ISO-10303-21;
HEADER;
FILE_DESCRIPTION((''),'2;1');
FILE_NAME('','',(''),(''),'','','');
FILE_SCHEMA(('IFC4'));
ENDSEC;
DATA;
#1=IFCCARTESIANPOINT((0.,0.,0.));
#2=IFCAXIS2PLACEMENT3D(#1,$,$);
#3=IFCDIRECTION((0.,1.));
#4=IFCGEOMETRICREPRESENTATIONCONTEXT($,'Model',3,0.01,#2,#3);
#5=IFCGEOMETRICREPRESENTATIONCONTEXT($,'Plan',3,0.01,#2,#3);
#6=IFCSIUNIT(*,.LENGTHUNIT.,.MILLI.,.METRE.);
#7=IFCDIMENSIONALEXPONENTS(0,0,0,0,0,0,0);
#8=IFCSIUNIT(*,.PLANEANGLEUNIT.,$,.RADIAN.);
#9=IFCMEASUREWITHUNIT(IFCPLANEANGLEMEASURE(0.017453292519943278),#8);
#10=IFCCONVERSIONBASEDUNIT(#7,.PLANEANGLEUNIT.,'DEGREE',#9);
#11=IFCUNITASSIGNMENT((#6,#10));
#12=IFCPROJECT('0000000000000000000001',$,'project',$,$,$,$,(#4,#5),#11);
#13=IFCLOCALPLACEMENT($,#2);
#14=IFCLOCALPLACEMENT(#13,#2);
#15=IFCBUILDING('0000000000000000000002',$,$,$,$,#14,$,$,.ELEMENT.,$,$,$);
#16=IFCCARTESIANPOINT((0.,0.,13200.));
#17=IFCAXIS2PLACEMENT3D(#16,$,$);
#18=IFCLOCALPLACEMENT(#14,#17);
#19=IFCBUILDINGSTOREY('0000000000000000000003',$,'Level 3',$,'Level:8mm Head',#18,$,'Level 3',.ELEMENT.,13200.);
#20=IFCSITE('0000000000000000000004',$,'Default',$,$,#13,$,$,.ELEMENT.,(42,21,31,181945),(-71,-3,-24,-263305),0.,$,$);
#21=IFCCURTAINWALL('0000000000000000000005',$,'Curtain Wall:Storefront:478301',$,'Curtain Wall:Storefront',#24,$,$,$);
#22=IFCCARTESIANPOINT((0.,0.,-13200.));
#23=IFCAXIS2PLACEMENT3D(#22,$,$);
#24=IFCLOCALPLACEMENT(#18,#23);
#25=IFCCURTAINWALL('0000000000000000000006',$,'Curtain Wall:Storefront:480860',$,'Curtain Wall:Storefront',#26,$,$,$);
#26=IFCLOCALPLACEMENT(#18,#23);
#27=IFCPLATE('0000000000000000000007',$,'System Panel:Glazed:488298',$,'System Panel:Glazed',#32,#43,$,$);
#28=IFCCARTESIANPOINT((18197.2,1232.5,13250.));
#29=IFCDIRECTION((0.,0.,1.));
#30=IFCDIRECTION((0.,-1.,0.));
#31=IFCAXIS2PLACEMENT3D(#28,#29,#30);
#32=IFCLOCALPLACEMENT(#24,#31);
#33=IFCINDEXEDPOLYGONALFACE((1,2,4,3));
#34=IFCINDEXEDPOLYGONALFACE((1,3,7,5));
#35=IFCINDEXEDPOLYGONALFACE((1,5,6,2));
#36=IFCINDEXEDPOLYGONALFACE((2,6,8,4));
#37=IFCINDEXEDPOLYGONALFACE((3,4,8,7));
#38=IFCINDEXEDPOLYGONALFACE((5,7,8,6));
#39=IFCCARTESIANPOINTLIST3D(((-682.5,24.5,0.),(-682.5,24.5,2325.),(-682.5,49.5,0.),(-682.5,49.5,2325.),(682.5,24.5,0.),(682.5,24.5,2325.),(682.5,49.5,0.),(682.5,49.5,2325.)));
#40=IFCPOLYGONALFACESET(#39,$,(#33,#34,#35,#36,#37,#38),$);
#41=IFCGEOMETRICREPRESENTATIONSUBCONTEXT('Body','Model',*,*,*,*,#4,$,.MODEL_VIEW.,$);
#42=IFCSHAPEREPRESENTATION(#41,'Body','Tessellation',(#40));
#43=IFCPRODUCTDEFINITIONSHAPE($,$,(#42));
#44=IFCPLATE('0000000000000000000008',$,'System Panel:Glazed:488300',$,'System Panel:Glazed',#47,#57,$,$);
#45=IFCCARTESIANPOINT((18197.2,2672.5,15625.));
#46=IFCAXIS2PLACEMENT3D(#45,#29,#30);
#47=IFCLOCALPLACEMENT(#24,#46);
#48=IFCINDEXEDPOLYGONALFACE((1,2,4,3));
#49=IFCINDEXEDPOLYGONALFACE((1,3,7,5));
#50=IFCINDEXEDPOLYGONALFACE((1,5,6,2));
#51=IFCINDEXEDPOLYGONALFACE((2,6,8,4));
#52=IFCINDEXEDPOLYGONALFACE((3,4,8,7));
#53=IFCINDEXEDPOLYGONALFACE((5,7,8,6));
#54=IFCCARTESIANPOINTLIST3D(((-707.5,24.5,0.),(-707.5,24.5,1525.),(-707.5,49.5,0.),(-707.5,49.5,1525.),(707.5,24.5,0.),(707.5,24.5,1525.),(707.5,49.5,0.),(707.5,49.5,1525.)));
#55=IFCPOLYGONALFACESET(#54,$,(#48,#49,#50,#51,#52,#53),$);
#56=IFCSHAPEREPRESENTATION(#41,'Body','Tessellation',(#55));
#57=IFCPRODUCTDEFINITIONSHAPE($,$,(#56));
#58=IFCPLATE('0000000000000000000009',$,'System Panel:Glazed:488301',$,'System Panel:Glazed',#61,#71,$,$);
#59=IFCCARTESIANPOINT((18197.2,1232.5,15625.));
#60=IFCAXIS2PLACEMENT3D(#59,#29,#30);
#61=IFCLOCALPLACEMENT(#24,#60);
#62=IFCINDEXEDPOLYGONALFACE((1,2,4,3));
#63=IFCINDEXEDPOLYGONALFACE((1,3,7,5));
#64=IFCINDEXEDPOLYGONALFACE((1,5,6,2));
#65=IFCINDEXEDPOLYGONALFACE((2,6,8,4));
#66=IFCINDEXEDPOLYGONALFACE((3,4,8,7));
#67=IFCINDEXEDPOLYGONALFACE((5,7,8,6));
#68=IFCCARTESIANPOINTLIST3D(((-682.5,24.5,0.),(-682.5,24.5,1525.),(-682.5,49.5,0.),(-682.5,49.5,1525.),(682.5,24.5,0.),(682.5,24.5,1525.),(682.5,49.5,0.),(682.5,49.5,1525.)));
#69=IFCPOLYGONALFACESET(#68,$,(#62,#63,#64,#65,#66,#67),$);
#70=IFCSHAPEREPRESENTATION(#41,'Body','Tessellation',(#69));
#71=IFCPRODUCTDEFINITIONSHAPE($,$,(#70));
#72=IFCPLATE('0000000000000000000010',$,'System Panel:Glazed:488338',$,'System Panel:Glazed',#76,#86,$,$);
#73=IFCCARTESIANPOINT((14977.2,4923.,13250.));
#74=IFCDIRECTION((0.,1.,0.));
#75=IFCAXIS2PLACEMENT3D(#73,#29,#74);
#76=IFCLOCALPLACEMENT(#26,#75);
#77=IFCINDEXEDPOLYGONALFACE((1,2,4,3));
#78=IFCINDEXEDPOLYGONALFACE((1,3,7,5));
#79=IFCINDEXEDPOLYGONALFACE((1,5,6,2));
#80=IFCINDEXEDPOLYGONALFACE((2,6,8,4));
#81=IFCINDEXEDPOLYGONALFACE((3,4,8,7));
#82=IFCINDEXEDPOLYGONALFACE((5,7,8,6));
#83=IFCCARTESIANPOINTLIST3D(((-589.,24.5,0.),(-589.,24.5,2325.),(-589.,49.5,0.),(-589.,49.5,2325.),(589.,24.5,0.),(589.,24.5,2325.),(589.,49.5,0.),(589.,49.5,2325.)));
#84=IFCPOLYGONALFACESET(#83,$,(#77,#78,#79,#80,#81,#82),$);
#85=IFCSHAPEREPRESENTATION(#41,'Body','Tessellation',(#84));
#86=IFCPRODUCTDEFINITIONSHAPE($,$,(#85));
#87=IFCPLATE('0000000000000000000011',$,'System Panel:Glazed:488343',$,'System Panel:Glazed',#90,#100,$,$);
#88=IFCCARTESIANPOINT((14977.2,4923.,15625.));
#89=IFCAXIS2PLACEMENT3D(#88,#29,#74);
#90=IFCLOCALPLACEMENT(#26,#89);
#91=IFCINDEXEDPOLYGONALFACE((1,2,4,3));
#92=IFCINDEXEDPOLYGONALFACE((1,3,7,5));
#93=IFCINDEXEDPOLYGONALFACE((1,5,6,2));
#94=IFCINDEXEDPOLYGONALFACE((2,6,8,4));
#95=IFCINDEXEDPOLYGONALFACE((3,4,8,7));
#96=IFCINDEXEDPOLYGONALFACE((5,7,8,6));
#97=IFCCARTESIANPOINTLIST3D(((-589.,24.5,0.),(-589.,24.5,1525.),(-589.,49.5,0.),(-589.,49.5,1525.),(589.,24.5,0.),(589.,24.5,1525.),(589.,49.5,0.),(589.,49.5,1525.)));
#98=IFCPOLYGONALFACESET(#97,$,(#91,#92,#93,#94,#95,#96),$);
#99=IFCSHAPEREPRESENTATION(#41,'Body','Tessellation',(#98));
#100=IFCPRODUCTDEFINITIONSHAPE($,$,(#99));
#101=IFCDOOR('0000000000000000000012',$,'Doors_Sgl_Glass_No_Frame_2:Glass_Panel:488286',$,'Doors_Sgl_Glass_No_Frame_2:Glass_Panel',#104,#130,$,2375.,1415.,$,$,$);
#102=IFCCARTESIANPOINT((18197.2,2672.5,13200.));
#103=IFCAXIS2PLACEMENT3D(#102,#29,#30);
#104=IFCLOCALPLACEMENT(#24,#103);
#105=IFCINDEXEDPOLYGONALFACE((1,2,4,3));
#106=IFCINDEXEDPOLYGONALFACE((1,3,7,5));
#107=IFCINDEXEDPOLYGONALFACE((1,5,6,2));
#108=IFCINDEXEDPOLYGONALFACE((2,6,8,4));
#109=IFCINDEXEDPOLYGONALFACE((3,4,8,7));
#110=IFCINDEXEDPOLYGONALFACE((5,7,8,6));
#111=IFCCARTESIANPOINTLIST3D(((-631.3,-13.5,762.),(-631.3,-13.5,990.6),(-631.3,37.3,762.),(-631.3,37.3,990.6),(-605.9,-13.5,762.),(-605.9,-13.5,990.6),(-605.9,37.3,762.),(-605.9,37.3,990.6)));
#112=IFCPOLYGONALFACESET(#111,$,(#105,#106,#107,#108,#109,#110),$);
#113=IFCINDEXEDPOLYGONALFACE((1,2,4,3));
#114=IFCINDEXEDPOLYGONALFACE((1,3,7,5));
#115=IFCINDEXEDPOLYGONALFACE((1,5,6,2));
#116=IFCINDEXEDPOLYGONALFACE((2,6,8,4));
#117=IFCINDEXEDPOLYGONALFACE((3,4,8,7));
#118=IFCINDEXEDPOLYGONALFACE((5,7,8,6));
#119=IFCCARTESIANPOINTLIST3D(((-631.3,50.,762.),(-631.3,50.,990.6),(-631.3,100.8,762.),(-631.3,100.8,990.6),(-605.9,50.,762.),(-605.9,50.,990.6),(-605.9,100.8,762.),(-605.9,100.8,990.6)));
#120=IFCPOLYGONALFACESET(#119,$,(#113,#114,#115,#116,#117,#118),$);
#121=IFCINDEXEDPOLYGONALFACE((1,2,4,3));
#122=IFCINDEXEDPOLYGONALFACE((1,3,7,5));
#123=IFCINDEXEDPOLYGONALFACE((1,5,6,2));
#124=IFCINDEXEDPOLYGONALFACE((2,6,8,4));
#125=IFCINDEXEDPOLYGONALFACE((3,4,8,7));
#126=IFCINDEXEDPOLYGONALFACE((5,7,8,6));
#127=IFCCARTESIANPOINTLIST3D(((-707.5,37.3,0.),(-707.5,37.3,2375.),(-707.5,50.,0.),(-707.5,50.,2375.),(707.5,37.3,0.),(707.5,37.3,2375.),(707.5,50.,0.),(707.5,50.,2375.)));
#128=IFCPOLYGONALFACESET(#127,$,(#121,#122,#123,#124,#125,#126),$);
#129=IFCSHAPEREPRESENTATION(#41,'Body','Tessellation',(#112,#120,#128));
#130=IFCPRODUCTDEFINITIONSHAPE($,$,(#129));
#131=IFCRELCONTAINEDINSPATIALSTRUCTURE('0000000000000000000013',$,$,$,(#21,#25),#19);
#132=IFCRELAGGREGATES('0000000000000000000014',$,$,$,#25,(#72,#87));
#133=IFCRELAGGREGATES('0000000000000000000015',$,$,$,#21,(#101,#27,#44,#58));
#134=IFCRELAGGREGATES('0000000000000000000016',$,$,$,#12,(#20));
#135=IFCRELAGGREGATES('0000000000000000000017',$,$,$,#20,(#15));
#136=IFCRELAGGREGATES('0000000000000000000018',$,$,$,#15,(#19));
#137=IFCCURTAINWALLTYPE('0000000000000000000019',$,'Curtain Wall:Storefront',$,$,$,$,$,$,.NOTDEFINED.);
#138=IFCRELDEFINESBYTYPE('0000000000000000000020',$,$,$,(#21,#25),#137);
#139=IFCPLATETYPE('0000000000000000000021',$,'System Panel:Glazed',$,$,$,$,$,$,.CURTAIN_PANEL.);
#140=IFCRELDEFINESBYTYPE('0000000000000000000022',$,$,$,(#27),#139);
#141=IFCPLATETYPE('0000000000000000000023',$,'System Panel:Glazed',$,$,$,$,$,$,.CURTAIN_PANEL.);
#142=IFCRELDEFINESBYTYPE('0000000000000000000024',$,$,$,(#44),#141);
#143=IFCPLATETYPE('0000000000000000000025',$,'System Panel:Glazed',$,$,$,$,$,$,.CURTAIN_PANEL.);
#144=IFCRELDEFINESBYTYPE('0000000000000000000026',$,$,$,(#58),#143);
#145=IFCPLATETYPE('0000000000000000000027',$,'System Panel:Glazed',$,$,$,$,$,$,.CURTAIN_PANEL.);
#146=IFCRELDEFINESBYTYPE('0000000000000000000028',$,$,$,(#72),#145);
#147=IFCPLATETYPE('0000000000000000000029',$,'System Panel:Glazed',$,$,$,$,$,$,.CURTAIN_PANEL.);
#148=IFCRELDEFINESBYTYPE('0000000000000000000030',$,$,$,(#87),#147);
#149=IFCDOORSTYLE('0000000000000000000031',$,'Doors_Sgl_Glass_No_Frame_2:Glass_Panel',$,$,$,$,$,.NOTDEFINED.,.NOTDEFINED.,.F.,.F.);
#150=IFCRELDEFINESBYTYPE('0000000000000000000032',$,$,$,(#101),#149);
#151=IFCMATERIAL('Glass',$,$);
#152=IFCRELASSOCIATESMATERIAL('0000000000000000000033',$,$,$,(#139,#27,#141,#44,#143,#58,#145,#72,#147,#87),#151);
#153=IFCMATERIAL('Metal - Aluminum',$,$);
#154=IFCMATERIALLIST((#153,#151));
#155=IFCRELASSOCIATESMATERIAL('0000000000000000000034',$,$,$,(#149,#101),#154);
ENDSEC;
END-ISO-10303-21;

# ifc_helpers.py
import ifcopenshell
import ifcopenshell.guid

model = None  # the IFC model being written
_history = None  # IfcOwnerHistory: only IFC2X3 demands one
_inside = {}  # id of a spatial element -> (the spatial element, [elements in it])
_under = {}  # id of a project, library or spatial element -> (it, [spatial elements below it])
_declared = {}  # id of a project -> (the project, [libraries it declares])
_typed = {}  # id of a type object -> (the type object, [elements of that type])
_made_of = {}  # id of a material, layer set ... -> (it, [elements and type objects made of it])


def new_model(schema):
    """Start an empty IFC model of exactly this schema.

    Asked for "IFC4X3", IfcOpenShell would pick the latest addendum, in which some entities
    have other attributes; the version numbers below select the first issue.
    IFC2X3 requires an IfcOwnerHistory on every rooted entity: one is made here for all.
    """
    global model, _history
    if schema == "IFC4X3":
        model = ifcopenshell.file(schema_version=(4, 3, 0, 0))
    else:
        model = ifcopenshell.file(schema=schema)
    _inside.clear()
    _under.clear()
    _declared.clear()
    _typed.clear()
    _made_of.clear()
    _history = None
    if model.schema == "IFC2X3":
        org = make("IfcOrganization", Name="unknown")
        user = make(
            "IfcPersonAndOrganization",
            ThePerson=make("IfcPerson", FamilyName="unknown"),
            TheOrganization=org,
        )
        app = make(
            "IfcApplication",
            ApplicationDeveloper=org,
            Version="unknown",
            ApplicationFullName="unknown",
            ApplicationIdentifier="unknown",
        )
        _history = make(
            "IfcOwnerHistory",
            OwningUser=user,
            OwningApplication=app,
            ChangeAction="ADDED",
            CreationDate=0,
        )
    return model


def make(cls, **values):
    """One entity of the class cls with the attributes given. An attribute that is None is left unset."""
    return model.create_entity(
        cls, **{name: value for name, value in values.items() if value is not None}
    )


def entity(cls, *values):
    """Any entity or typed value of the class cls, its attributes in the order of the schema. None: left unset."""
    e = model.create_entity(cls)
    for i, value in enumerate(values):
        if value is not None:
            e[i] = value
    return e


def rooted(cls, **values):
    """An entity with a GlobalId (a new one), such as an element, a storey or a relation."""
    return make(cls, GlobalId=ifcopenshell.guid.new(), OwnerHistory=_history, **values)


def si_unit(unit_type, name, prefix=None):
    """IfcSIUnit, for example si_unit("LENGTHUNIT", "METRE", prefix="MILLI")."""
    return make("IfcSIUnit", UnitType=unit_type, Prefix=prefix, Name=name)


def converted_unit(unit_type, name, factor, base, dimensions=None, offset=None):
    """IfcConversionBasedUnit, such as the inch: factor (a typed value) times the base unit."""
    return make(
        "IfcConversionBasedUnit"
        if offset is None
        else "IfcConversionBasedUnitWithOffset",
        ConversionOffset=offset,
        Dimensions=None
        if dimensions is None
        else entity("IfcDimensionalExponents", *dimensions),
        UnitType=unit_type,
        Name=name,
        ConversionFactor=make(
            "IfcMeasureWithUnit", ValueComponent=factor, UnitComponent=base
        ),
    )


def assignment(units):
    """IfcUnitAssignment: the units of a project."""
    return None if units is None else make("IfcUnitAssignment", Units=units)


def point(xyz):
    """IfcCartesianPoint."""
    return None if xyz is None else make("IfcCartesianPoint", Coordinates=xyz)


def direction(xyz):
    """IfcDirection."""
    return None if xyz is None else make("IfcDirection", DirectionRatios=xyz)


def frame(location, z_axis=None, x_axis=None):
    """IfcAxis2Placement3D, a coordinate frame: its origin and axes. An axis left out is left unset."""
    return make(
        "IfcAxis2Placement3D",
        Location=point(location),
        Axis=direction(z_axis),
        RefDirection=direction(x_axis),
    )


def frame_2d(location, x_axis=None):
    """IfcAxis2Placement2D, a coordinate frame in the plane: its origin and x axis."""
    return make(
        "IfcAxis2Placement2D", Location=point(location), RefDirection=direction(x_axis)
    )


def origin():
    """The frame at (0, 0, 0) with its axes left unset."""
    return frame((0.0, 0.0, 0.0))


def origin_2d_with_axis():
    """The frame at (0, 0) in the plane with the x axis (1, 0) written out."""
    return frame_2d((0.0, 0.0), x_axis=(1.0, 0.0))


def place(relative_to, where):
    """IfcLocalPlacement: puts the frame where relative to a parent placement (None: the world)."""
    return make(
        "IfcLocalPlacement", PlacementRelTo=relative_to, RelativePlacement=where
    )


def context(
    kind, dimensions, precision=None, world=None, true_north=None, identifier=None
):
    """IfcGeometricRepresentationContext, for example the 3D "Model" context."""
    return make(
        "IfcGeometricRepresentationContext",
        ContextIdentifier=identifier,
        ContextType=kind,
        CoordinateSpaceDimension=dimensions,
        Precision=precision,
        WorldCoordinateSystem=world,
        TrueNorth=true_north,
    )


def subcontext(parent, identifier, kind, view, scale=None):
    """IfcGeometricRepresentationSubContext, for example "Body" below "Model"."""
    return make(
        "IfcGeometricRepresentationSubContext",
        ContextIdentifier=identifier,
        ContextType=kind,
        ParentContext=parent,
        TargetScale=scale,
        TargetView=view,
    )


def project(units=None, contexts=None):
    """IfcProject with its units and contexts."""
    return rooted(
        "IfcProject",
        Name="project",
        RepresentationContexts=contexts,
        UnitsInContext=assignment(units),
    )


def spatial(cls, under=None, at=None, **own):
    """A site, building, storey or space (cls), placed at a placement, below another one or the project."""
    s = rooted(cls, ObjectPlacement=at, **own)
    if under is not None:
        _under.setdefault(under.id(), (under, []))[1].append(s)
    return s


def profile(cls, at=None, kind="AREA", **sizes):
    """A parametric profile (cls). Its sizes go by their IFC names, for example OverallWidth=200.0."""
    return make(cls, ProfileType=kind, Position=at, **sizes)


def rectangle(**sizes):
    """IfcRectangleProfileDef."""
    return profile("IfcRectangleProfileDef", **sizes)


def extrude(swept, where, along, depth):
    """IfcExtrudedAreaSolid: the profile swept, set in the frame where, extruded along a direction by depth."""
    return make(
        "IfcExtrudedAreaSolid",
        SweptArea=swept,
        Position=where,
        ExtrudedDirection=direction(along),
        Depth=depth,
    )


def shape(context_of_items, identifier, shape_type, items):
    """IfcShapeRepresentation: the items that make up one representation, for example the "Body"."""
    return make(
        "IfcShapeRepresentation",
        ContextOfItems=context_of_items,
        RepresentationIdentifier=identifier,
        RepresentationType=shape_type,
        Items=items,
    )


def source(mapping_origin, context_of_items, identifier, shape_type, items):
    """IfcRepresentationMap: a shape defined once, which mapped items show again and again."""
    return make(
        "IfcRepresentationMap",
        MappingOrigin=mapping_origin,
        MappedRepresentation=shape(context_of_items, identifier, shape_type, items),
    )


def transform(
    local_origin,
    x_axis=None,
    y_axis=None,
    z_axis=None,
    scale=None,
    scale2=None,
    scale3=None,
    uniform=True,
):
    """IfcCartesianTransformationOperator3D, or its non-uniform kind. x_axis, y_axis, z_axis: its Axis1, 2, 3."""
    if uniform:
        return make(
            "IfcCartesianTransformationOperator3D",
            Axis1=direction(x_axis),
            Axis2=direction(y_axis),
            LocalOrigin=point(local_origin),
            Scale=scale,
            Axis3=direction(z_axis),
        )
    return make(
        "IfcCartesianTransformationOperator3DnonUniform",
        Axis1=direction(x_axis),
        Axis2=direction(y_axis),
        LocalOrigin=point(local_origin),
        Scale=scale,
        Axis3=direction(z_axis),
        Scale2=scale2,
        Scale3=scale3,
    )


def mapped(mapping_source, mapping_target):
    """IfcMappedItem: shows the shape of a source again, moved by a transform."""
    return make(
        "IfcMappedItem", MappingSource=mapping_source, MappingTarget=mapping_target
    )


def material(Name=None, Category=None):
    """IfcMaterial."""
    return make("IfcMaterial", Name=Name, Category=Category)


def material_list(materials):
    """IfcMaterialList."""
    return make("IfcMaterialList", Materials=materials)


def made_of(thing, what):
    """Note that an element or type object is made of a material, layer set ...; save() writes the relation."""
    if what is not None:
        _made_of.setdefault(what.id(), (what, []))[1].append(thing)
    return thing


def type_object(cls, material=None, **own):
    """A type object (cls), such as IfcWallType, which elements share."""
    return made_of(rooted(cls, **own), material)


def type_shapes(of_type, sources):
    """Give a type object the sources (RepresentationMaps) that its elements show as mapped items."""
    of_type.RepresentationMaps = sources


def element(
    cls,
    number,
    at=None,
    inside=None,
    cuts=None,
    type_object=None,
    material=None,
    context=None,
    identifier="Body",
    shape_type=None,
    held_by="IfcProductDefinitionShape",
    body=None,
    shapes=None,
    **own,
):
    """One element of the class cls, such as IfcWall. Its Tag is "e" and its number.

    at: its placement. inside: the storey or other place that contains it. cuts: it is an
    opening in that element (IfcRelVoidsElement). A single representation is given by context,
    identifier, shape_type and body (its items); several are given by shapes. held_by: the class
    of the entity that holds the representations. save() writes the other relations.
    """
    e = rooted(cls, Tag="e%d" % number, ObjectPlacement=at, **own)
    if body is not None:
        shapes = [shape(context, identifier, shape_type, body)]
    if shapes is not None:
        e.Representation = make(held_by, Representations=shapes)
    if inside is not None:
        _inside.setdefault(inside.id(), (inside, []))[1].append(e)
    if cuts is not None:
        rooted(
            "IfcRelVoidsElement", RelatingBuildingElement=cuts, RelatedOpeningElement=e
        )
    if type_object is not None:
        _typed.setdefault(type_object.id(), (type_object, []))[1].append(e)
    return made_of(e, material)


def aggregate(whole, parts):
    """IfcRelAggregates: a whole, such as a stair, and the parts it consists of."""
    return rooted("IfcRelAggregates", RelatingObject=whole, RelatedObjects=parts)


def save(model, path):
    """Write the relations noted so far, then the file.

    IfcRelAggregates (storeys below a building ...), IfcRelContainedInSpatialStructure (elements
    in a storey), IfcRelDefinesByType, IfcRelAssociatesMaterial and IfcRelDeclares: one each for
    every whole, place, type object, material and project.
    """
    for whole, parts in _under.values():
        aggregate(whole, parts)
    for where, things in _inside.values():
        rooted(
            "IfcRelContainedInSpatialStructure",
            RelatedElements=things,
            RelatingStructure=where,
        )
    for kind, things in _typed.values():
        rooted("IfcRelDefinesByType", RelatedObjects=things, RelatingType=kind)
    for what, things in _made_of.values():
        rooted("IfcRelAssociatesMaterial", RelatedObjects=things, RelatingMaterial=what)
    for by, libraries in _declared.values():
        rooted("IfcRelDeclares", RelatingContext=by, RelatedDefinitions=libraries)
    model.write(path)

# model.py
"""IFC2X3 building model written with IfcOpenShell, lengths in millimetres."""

from ifc_helpers import new_model, entity, si_unit, converted_unit, direction, frame, frame_2d, origin, origin_2d_with_axis, place, context, subcontext, project, spatial, rectangle, extrude, source, transform, mapped, material, material_list, type_object, type_shapes, element, aggregate, save


model = new_model("IFC2X3")

# Units and contexts
model_context = context("Model", 3, precision=0.01, world=origin(), true_north=direction((0.0, 1.0)))
plan_context = context("Plan", 3, precision=0.01, world=origin(), true_north=direction((0.0, 1.0)))
body_context = subcontext(model_context, "Body", "Model", "MODEL_VIEW")
ifc_project = project(units=[si_unit("LENGTHUNIT", "METRE", prefix="MILLI"), converted_unit("PLANEANGLEUNIT", "DEGREE", entity("IfcPlaneAngleMeasure", 0.017453292519943278), si_unit("PLANEANGLEUNIT", "RADIAN"), dimensions=[0, 0, 0, 0, 0, 0, 0])], contexts=[model_context, plan_context])

# Site, building, storey
site_placement = place(None, origin())
site = spatial("IfcSite", under=ifc_project, at=site_placement, Name="Default", CompositionType="ELEMENT", RefLatitude=(42, 21, 31, 181945), RefLongitude=(-71, -3, -24, -263305), RefElevation=0.0)
building_placement = place(site_placement, origin())
building = spatial("IfcBuilding", under=site, at=building_placement, CompositionType="ELEMENT")
storey_placement = place(building_placement, frame((0.0, 0.0, 13200.0)))
storey = spatial("IfcBuildingStorey", under=building, at=storey_placement, Name="Level 3", ObjectType="Level:8mm Head", LongName="Level 3", CompositionType="ELEMENT", Elevation=13200.0)

# Curtain walls
curtain_wall_type = type_object("IfcCurtainWallType", Name="Curtain Wall:Storefront", PredefinedType="NOTDEFINED")
curtain_wall_1_placement = place(storey_placement, frame((0.0, 0.0, -13200.0)))
curtain_wall_1 = element("IfcCurtainWall", 1, at=curtain_wall_1_placement, inside=storey, type_object=curtain_wall_type, Name="Curtain Wall:Storefront:478301", ObjectType="Curtain Wall:Storefront")
curtain_wall_2_placement = place(storey_placement, frame((0.0, 0.0, -13200.0)))
curtain_wall_2 = element("IfcCurtainWall", 2, at=curtain_wall_2_placement, inside=storey, type_object=curtain_wall_type, Name="Curtain Wall:Storefront:480860", ObjectType="Curtain Wall:Storefront")

# Plates
ifc_material_1 = material(Name="Glass")
plate_type_1 = type_object("IfcPlateType", Name="System Panel:Glazed", PredefinedType="CURTAIN_PANEL", material=ifc_material_1)
shared_shape_1 = source(origin(), body_context, "Body", "SweptSolid", [
    extrude(rectangle(XDim=25.0, YDim=1365.0, at=origin_2d_with_axis()), frame((0.0, 37.0, 0.0), z_axis=(0.0, 0.0, 1.0), x_axis=(0.0, 1.0, 0.0)), (0.0, 0.0, 1.0), 2325.0),
])
type_shapes(plate_type_1, [shared_shape_1])
plate_1_placement = place(curtain_wall_1_placement, frame((18197.2, 1232.5, 13250.0), z_axis=(0.0, 0.0, 1.0), x_axis=(0.0, -1.0, 0.0)))
plate_1 = element("IfcPlate", 3, at=plate_1_placement, type_object=plate_type_1, material=ifc_material_1, Name="System Panel:Glazed:488298", ObjectType="System Panel:Glazed", context=body_context, shape_type="MappedRepresentation", body=[
    mapped(shared_shape_1, transform((0.0, 0.0, 0.0), scale=1.0)),
])
plate_type_2 = type_object("IfcPlateType", Name="System Panel:Glazed", PredefinedType="CURTAIN_PANEL", material=ifc_material_1)
shared_shape_2 = source(origin(), body_context, "Body", "SweptSolid", [
    extrude(rectangle(XDim=25.0, YDim=1415.0, at=origin_2d_with_axis()), frame((0.0, 37.0, 0.0), z_axis=(0.0, 0.0, 1.0), x_axis=(0.0, 1.0, 0.0)), (0.0, 0.0, 1.0), 1525.0),
])
type_shapes(plate_type_2, [shared_shape_2])
plate_2_placement = place(curtain_wall_1_placement, frame((18197.2, 2672.5, 15625.0), z_axis=(0.0, 0.0, 1.0), x_axis=(0.0, -1.0, 0.0)))
plate_2 = element("IfcPlate", 4, at=plate_2_placement, type_object=plate_type_2, material=ifc_material_1, Name="System Panel:Glazed:488300", ObjectType="System Panel:Glazed", context=body_context, shape_type="MappedRepresentation", body=[
    mapped(shared_shape_2, transform((0.0, 0.0, 0.0), scale=1.0)),
])
plate_type_3 = type_object("IfcPlateType", Name="System Panel:Glazed", PredefinedType="CURTAIN_PANEL", material=ifc_material_1)
shared_shape_3 = source(origin(), body_context, "Body", "SweptSolid", [
    extrude(rectangle(XDim=25.0, YDim=1365.0, at=origin_2d_with_axis()), frame((0.0, 37.0, 0.0), z_axis=(0.0, 0.0, 1.0), x_axis=(0.0, 1.0, 0.0)), (0.0, 0.0, 1.0), 1525.0),
])
type_shapes(plate_type_3, [shared_shape_3])
plate_3_placement = place(curtain_wall_1_placement, frame((18197.2, 1232.5, 15625.0), z_axis=(0.0, 0.0, 1.0), x_axis=(0.0, -1.0, 0.0)))
plate_3 = element("IfcPlate", 5, at=plate_3_placement, type_object=plate_type_3, material=ifc_material_1, Name="System Panel:Glazed:488301", ObjectType="System Panel:Glazed", context=body_context, shape_type="MappedRepresentation", body=[
    mapped(shared_shape_3, transform((0.0, 0.0, 0.0), scale=1.0)),
])
plate_type_4 = type_object("IfcPlateType", Name="System Panel:Glazed", PredefinedType="CURTAIN_PANEL", material=ifc_material_1)
shared_shape_4 = source(origin(), body_context, "Body", "SweptSolid", [
    extrude(rectangle(XDim=25.0, YDim=1178.0, at=origin_2d_with_axis()), frame((0.0, 37.0, 0.0), z_axis=(0.0, 0.0, 1.0), x_axis=(0.0, 1.0, 0.0)), (0.0, 0.0, 1.0), 2325.0),
])
type_shapes(plate_type_4, [shared_shape_4])
plate_4_placement = place(curtain_wall_2_placement, frame((14977.2, 4923.0, 13250.0), z_axis=(0.0, 0.0, 1.0), x_axis=(0.0, 1.0, 0.0)))
plate_4 = element("IfcPlate", 6, at=plate_4_placement, type_object=plate_type_4, material=ifc_material_1, Name="System Panel:Glazed:488338", ObjectType="System Panel:Glazed", context=body_context, shape_type="MappedRepresentation", body=[
    mapped(shared_shape_4, transform((0.0, 0.0, 0.0), scale=1.0)),
])
plate_type_5 = type_object("IfcPlateType", Name="System Panel:Glazed", PredefinedType="CURTAIN_PANEL", material=ifc_material_1)
shared_shape_5 = source(origin(), body_context, "Body", "SweptSolid", [
    extrude(rectangle(XDim=25.0, YDim=1178.0, at=origin_2d_with_axis()), frame((0.0, 37.0, 0.0), z_axis=(0.0, 0.0, 1.0), x_axis=(0.0, 1.0, 0.0)), (0.0, 0.0, 1.0), 1525.0),
])
type_shapes(plate_type_5, [shared_shape_5])
plate_5_placement = place(curtain_wall_2_placement, frame((14977.2, 4923.0, 15625.0), z_axis=(0.0, 0.0, 1.0), x_axis=(0.0, 1.0, 0.0)))
plate_5 = element("IfcPlate", 7, at=plate_5_placement, type_object=plate_type_5, material=ifc_material_1, Name="System Panel:Glazed:488343", ObjectType="System Panel:Glazed", context=body_context, shape_type="MappedRepresentation", body=[
    mapped(shared_shape_5, transform((0.0, 0.0, 0.0), scale=1.0)),
])
aggregate(curtain_wall_2, [plate_4, plate_5])

# Door
ifc_material_2 = material(Name="Metal - Aluminum")
ifc_material_list = material_list([ifc_material_2, ifc_material_1])
door_style = type_object("IfcDoorStyle", Name="Doors_Sgl_Glass_No_Frame_2:Glass_Panel", ConstructionType="NOTDEFINED", OperationType="NOTDEFINED", ParameterTakesPrecedence=False, Sizeable=False, material=ifc_material_list)
shared_shape_6 = source(origin(), body_context, "Body", "SweptSolid", [
    extrude(rectangle(XDim=50.8, YDim=25.4, at=frame_2d((0.0, 0.0), x_axis=(1.0, 0.0))), frame((-618.6, 11.9, 762.0), z_axis=(0.0, 0.0, 1.0), x_axis=(0.0, 1.0, 0.0)), (0.0, 0.0, 1.0), 228.6),
    extrude(rectangle(XDim=50.8, YDim=25.4, at=frame_2d((0.0, 0.0), x_axis=(1.0, 0.0))), frame((-618.6, 75.4, 762.0), z_axis=(0.0, 0.0, 1.0), x_axis=(0.0, -1.0, 0.0)), (0.0, 0.0, 1.0), 228.6),
    extrude(rectangle(XDim=1415.0, YDim=12.7, at=frame_2d((0.0, 0.0), x_axis=(1.0, 0.0))), frame((0.0, 43.7, 0.0), z_axis=(0.0, 0.0, 1.0), x_axis=(-1.0, 0.0, 0.0)), (0.0, 0.0, 1.0), 2375.0),
])
type_shapes(door_style, [shared_shape_6])
door_placement = place(curtain_wall_1_placement, frame((18197.2, 2672.5, 13200.0), z_axis=(0.0, 0.0, 1.0), x_axis=(0.0, -1.0, 0.0)))
door = element("IfcDoor", 8, at=door_placement, type_object=door_style, material=ifc_material_list, Name="Doors_Sgl_Glass_No_Frame_2:Glass_Panel:488286", ObjectType="Doors_Sgl_Glass_No_Frame_2:Glass_Panel", OverallHeight=2375.0, OverallWidth=1415.0, context=body_context, shape_type="MappedRepresentation", body=[
    mapped(shared_shape_6, transform((0.0, 0.0, 0.0), scale=1.0)),
])
aggregate(curtain_wall_1, [door, plate_1, plate_2, plate_3])

save(model, "model.ifc")
